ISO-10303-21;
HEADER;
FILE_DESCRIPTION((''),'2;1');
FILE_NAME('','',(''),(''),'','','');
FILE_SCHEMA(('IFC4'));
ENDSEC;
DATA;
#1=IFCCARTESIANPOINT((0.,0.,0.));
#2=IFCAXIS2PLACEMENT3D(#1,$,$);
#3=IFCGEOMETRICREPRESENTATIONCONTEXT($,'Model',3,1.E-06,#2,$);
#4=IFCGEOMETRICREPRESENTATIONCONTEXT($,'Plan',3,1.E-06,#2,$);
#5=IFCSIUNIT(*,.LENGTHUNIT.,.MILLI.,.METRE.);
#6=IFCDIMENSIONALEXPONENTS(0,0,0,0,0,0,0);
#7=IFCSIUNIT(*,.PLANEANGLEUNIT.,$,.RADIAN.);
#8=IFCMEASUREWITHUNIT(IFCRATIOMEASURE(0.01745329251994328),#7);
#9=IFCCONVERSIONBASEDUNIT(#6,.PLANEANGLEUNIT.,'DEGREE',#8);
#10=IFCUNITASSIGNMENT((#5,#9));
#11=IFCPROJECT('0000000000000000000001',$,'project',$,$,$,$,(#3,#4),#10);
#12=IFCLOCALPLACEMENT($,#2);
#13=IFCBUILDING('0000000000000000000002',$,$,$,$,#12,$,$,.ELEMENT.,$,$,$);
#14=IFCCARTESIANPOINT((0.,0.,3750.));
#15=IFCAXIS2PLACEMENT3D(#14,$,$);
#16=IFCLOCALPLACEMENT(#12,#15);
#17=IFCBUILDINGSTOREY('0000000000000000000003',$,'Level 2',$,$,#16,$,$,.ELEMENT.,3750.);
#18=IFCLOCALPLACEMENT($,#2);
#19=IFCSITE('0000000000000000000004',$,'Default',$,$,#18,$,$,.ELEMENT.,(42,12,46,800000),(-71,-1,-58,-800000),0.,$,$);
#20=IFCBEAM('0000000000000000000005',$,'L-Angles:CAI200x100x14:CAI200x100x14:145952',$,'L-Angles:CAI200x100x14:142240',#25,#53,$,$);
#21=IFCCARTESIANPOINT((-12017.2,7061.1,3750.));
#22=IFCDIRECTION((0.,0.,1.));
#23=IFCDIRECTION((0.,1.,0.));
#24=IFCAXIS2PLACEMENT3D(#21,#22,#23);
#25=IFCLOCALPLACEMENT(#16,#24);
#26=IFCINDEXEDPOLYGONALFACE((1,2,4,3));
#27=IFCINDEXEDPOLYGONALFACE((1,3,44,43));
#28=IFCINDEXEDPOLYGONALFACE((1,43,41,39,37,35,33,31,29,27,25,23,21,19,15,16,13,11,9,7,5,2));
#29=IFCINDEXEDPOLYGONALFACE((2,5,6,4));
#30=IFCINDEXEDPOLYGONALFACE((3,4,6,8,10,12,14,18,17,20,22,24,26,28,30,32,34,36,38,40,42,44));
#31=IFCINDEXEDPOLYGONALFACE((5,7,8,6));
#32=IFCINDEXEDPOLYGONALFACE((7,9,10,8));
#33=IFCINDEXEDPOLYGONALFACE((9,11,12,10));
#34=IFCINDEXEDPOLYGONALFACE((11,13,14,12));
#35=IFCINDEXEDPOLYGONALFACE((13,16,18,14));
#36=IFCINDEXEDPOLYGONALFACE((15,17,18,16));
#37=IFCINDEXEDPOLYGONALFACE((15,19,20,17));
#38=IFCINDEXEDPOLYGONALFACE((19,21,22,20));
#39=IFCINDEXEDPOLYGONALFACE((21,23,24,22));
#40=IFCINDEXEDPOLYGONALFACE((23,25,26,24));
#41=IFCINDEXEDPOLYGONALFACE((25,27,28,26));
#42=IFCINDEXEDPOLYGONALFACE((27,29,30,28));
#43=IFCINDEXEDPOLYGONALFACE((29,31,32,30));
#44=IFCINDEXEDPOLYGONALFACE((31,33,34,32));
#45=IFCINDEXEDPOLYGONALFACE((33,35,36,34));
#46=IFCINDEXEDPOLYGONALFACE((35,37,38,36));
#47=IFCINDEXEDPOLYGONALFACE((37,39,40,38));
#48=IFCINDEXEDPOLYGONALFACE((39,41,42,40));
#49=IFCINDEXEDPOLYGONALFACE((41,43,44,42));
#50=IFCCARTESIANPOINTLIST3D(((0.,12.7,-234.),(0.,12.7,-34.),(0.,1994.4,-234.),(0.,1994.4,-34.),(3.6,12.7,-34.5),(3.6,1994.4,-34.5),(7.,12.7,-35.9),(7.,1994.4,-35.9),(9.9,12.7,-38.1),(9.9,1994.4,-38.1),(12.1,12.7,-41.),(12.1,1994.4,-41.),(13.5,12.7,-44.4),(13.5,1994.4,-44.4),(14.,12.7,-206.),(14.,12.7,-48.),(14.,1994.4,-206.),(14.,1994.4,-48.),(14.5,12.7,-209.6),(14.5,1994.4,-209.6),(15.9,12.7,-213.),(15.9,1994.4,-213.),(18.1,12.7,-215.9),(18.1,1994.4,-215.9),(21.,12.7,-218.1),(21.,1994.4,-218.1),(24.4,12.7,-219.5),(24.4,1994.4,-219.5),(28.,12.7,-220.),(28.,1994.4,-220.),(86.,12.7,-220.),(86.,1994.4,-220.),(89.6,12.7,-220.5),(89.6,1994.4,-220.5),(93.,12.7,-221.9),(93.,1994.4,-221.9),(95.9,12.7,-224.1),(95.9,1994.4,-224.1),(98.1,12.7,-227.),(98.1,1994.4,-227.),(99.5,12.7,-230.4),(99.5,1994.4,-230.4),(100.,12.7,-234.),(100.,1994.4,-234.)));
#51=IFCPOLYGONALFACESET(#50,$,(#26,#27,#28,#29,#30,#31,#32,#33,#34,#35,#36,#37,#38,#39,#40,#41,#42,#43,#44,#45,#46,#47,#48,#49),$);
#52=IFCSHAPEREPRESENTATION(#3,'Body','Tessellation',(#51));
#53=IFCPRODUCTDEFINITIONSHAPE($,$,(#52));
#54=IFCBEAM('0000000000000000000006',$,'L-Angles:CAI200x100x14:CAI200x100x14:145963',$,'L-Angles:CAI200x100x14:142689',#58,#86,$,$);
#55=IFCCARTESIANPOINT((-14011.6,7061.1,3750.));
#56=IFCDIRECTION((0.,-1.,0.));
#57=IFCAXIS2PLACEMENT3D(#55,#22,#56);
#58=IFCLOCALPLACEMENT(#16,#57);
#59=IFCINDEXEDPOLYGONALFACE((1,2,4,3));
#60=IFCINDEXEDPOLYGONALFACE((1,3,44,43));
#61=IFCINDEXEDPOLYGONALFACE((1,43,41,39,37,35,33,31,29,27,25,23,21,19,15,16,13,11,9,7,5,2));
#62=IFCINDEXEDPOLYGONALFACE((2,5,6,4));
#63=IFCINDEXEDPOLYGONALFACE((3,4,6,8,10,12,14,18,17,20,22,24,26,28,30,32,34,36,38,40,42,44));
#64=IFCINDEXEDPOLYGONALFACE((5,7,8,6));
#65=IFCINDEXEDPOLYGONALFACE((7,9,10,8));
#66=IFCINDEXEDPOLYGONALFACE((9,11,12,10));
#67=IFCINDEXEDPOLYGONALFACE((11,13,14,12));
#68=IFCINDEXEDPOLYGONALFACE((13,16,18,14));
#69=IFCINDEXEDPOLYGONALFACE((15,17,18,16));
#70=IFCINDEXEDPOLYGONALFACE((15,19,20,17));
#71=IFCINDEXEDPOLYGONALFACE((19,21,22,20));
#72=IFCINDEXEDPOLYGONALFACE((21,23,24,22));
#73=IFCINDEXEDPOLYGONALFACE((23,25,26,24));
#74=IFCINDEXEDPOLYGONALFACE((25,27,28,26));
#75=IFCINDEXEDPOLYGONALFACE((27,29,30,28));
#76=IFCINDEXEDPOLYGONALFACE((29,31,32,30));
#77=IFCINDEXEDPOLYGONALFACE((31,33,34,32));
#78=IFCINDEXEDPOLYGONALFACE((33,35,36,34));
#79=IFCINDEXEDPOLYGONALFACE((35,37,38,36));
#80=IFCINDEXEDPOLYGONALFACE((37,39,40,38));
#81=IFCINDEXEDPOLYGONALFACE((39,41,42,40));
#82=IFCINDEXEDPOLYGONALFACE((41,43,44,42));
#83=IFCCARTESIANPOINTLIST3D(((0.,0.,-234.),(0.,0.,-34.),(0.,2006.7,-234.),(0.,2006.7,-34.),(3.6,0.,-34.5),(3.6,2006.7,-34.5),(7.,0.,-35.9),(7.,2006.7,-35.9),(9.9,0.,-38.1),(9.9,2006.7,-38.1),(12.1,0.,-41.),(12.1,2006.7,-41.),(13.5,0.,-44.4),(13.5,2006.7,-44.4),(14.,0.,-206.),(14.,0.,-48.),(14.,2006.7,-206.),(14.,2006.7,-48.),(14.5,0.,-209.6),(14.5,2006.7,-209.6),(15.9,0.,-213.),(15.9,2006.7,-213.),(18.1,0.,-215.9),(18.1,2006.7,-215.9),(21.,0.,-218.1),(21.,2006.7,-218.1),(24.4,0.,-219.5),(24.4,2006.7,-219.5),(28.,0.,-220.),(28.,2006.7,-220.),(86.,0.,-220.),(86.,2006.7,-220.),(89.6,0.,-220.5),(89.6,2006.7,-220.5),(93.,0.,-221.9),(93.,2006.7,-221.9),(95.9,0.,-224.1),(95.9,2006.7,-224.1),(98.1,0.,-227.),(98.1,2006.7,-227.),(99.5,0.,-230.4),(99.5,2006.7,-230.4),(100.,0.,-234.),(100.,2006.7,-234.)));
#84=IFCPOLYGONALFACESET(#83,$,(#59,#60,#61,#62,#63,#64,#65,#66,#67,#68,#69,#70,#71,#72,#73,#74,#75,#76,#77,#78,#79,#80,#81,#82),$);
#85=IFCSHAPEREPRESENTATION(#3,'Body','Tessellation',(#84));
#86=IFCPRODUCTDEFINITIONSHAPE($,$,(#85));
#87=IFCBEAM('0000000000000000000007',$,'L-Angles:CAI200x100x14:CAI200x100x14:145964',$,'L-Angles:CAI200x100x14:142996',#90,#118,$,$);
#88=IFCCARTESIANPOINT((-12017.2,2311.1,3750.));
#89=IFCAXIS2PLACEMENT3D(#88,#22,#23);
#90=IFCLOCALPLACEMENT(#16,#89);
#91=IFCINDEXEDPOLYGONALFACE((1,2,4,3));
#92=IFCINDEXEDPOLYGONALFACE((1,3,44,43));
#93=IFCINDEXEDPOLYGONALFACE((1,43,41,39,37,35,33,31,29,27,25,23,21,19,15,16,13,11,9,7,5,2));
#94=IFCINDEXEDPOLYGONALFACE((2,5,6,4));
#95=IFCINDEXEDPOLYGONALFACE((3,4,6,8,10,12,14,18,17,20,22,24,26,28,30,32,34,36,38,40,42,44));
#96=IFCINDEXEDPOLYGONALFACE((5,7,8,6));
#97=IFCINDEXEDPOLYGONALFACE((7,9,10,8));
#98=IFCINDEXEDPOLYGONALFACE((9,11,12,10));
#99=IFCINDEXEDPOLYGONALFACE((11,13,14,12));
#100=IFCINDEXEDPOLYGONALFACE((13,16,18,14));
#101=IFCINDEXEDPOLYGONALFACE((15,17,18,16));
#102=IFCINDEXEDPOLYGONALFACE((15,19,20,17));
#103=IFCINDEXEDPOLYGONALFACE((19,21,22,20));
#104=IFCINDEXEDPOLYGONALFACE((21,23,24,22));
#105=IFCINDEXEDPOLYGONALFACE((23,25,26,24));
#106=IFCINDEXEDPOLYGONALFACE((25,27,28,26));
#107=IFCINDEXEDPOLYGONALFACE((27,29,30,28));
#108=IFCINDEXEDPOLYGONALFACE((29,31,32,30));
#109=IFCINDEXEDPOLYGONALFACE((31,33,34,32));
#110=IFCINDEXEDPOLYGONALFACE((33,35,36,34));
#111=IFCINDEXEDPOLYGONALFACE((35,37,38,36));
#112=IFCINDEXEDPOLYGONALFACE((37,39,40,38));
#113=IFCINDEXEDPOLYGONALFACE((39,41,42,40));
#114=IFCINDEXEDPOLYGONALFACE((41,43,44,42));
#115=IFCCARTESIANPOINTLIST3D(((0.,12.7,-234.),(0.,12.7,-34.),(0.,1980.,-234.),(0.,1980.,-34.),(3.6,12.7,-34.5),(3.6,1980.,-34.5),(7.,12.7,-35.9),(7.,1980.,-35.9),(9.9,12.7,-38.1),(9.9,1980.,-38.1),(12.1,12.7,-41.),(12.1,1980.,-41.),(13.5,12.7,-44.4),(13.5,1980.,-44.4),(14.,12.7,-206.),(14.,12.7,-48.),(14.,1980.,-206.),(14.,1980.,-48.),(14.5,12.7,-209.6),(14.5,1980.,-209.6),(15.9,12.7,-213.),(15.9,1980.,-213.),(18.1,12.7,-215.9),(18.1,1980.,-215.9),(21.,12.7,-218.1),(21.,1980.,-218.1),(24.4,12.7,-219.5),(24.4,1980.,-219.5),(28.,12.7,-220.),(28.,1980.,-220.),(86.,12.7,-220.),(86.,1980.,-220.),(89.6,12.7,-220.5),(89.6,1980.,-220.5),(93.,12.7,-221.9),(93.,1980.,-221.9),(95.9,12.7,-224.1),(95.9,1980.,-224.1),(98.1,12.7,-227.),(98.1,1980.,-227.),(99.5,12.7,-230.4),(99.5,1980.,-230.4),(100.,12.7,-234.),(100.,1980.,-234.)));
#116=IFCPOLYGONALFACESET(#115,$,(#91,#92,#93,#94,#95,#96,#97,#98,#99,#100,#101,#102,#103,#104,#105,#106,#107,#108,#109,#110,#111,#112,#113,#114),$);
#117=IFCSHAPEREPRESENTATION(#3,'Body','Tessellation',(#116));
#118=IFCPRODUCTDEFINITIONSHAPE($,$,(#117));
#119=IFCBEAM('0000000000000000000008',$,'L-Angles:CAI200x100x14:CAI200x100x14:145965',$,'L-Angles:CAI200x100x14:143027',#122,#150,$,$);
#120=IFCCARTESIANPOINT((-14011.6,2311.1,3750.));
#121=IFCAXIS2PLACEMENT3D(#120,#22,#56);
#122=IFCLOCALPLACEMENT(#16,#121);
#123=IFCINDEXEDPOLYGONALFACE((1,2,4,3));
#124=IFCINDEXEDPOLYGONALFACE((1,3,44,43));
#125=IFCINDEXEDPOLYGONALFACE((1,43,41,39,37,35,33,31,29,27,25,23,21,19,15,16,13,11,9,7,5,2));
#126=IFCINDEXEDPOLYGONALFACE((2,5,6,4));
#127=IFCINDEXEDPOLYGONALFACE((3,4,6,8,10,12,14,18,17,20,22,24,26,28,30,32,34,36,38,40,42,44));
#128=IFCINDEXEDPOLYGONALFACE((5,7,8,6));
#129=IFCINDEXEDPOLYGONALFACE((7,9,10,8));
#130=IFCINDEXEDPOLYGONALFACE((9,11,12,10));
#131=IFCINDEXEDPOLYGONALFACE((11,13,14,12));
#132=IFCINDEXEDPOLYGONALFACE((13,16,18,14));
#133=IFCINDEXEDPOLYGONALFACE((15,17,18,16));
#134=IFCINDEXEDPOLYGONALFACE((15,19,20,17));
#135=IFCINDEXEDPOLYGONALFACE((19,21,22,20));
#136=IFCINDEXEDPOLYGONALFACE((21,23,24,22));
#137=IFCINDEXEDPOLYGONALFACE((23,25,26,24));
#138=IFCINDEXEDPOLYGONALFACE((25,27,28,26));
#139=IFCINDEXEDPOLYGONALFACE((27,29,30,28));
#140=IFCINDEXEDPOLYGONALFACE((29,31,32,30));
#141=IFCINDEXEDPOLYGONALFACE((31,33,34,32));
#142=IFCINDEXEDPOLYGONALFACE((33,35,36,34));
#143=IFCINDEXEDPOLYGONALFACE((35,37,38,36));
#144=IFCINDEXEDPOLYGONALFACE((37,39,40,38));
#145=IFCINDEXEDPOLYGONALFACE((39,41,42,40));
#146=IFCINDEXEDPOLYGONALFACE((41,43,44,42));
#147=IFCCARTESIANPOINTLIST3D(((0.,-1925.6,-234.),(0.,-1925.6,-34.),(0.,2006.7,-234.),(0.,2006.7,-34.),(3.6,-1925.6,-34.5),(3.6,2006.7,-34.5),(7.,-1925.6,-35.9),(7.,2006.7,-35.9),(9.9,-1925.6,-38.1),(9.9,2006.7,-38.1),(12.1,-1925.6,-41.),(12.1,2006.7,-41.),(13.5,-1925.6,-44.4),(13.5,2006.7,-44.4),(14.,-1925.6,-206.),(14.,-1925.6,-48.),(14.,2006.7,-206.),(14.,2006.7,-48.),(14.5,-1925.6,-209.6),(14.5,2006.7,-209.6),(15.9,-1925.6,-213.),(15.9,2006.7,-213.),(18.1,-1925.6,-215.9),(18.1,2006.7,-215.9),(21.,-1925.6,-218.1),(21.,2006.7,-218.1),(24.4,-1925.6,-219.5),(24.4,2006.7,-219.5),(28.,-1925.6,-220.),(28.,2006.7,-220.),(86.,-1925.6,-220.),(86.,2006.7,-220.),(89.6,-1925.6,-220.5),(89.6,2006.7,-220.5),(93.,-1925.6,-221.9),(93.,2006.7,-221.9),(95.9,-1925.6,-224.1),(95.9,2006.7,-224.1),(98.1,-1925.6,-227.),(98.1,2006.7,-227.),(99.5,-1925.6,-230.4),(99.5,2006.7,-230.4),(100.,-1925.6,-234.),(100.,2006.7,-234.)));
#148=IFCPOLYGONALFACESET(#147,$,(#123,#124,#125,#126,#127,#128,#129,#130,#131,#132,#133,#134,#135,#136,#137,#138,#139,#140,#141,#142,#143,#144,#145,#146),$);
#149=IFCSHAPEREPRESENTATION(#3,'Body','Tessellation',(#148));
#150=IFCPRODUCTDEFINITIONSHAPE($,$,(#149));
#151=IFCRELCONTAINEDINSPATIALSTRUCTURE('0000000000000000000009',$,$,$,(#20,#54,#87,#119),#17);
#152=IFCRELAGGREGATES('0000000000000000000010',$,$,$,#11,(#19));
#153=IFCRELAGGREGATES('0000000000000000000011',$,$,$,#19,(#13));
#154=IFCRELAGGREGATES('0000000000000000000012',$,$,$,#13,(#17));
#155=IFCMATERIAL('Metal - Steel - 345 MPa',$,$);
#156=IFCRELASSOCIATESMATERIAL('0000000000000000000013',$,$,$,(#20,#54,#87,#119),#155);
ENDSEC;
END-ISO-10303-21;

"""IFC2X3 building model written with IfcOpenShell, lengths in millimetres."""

from ifc_helpers import new_model, entity, si_unit, converted_unit, frame, frame_2d, origin, place, context, project, spatial, polyline, circle_curve, parameter, trimmed, segment, composite_curve, outline, extrude, material, element, save


model = new_model("IFC2X3")

# Units and contexts
model_context = context("Model", 3, precision=1e-06, world=origin())
plan_context = context("Plan", 3, precision=1e-06, world=origin())
ifc_project = project(units=[si_unit("LENGTHUNIT", "METRE", prefix="MILLI"), converted_unit("PLANEANGLEUNIT", "DEGREE", entity("IfcRatioMeasure", 0.01745329251994328), si_unit("PLANEANGLEUNIT", "RADIAN"), dimensions=[0, 0, 0, 0, 0, 0, 0])], contexts=[model_context, plan_context])

# Site, building, storey
site_placement = place(None, origin())
site = spatial("IfcSite", under=ifc_project, at=site_placement, Name="Default", CompositionType="ELEMENT", RefLatitude=(42, 12, 46, 800000), RefLongitude=(-71, -1, -58, -800000), RefElevation=0.0)
building_placement = place(None, origin())
building = spatial("IfcBuilding", under=site, at=building_placement, CompositionType="ELEMENT")
storey_placement = place(building_placement, frame((0.0, 0.0, 3750.0)))
storey = spatial("IfcBuildingStorey", under=building, at=storey_placement, Name="Level 2", CompositionType="ELEMENT", Elevation=3750.0)

# Shared definitions
ifc_material_1 = material(Name="Metal - Steel - 345 MPa")

# Beams
beam_1_placement = place(storey_placement, frame((-12017.2, 7061.1, 3750.0), z_axis=(0.0, 0.0, 1.0), x_axis=(0.0, 1.0, 0.0)))
element("IfcBeam", 1, at=beam_1_placement, inside=storey, material=ifc_material_1, Name="L-Angles:CAI200x100x14:CAI200x100x14:145952", ObjectType="L-Angles:CAI200x100x14:142240", context=model_context, shape_type="SweptSolid", body=[
    extrude(outline(composite_curve([segment(polyline([(-34.6, -63.1), (65.4, -63.1)]), True, "CONTINUOUS"), segment(trimmed(circle_curve(frame_2d((51.4, -63.1), x_axis=(1.0, 0.0)), 14.0), [parameter(0.0)], [parameter(90.0)], True, "PARAMETER"), True, "CONTINUOUS"), segment(polyline([(51.4, -49.1), (-6.6, -49.1)]), True, "CONTINUOUS"), segment(trimmed(circle_curve(frame_2d((-6.6, -35.1), x_axis=(1.0, 0.0)), 14.0), [parameter(180.0)], [parameter(270.0)], True, "PARAMETER"), False, "CONTINUOUS"), segment(polyline([(-20.6, -35.1), (-20.6, 122.9)]), True, "CONTINUOUS"), segment(trimmed(circle_curve(frame_2d((-34.6, 122.9), x_axis=(1.0, 0.0)), 14.0), [parameter(0.0)], [parameter(90.0)], True, "PARAMETER"), True, "CONTINUOUS"), segment(polyline([(-34.6, 136.9), (-34.6, -63.1)]), True, "CONTINUOUS")], self_intersect=False)), frame((34.6, 1994.4, -170.9), z_axis=(0.0, -1.0, 0.0), x_axis=(1.0, 0.0, 0.0)), (0.0, 0.0, 1.0), 1981.7),
])
beam_2_placement = place(storey_placement, frame((-14011.6, 7061.1, 3750.0), z_axis=(0.0, 0.0, 1.0), x_axis=(0.0, -1.0, 0.0)))
element("IfcBeam", 2, at=beam_2_placement, inside=storey, material=ifc_material_1, Name="L-Angles:CAI200x100x14:CAI200x100x14:145963", ObjectType="L-Angles:CAI200x100x14:142689", context=model_context, shape_type="SweptSolid", body=[
    extrude(outline(composite_curve([segment(polyline([(-63.1, -34.6), (136.9, -34.6)]), True, "CONTINUOUS"), segment(trimmed(circle_curve(frame_2d((122.9, -34.6), x_axis=(0.0, 1.0)), 14.0), [parameter(270.0)], [parameter(0.0)], True, "PARAMETER"), True, "CONTINUOUS"), segment(polyline([(122.9, -20.6), (-35.1, -20.6)]), True, "CONTINUOUS"), segment(trimmed(circle_curve(frame_2d((-35.1, -6.6), x_axis=(0.0, 1.0)), 14.0), [parameter(90.0)], [parameter(180.0)], True, "PARAMETER"), False, "CONTINUOUS"), segment(polyline([(-49.1, -6.6), (-49.1, 51.4)]), True, "CONTINUOUS"), segment(trimmed(circle_curve(frame_2d((-63.1, 51.4), x_axis=(0.0, 1.0)), 14.0), [parameter(270.0)], [parameter(360.0)], True, "PARAMETER"), True, "CONTINUOUS"), segment(polyline([(-63.1, 65.4), (-63.1, -34.6)]), True, "CONTINUOUS")], self_intersect=False)), frame((34.6, 0.0, -170.9), z_axis=(0.0, 1.0, 0.0), x_axis=(0.0, 0.0, 1.0)), (0.0, 0.0, 1.0), 2006.7),
])
beam_3_placement = place(storey_placement, frame((-12017.2, 2311.1, 3750.0), z_axis=(0.0, 0.0, 1.0), x_axis=(0.0, 1.0, 0.0)))
element("IfcBeam", 3, at=beam_3_placement, inside=storey, material=ifc_material_1, Name="L-Angles:CAI200x100x14:CAI200x100x14:145964", ObjectType="L-Angles:CAI200x100x14:142996", context=model_context, shape_type="SweptSolid", body=[
    extrude(outline(composite_curve([segment(polyline([(-34.6, -63.1), (65.4, -63.1)]), True, "CONTINUOUS"), segment(trimmed(circle_curve(frame_2d((51.4, -63.1), x_axis=(0.0, 1.0)), 14.0), [parameter(270.0)], [parameter(360.0)], True, "PARAMETER"), True, "CONTINUOUS"), segment(polyline([(51.4, -49.1), (-6.6, -49.1)]), True, "CONTINUOUS"), segment(trimmed(circle_curve(frame_2d((-6.6, -35.1), x_axis=(-1.0, 0.0)), 14.0), [parameter(0.0)], [parameter(90.0)], True, "PARAMETER"), False, "CONTINUOUS"), segment(polyline([(-20.6, -35.1), (-20.6, 122.9)]), True, "CONTINUOUS"), segment(trimmed(circle_curve(frame_2d((-34.6, 122.9), x_axis=(0.0, 1.0)), 14.0), [parameter(270.0)], [parameter(0.0)], True, "PARAMETER"), True, "CONTINUOUS"), segment(polyline([(-34.6, 136.9), (-34.6, -63.1)]), True, "CONTINUOUS")], self_intersect=False)), frame((34.6, 1980.0, -170.9), z_axis=(0.0, -1.0, 0.0), x_axis=(1.0, 0.0, 0.0)), (0.0, 0.0, 1.0), 1967.3),
])
beam_4_placement = place(storey_placement, frame((-14011.6, 2311.1, 3750.0), z_axis=(0.0, 0.0, 1.0), x_axis=(0.0, -1.0, 0.0)))
element("IfcBeam", 4, at=beam_4_placement, inside=storey, material=ifc_material_1, Name="L-Angles:CAI200x100x14:CAI200x100x14:145965", ObjectType="L-Angles:CAI200x100x14:143027", context=model_context, shape_type="SweptSolid", body=[
    extrude(outline(composite_curve([segment(polyline([(-63.1, -34.6), (136.9, -34.6)]), True, "CONTINUOUS"), segment(trimmed(circle_curve(frame_2d((122.9, -34.6), x_axis=(1.0, 0.0)), 14.0), [parameter(360.0)], [parameter(90.0)], True, "PARAMETER"), True, "CONTINUOUS"), segment(polyline([(122.9, -20.6), (-35.1, -20.6)]), True, "CONTINUOUS"), segment(trimmed(circle_curve(frame_2d((-35.1, -6.6), x_axis=(0.0, -1.0)), 14.0), [parameter(270.0)], [parameter(360.0)], True, "PARAMETER"), False, "CONTINUOUS"), segment(polyline([(-49.1, -6.6), (-49.1, 51.4)]), True, "CONTINUOUS"), segment(trimmed(circle_curve(frame_2d((-63.1, 51.4), x_axis=(1.0, 0.0)), 14.0), [parameter(0.0)], [parameter(90.0)], True, "PARAMETER"), True, "CONTINUOUS"), segment(polyline([(-63.1, 65.4), (-63.1, -34.6)]), True, "CONTINUOUS")], self_intersect=False)), frame((34.6, -1925.6, -170.9), z_axis=(0.0, 1.0, 0.0), x_axis=(0.0, 0.0, 1.0)), (0.0, 0.0, 1.0), 3932.3),
])

save(model, "model.ifc")
